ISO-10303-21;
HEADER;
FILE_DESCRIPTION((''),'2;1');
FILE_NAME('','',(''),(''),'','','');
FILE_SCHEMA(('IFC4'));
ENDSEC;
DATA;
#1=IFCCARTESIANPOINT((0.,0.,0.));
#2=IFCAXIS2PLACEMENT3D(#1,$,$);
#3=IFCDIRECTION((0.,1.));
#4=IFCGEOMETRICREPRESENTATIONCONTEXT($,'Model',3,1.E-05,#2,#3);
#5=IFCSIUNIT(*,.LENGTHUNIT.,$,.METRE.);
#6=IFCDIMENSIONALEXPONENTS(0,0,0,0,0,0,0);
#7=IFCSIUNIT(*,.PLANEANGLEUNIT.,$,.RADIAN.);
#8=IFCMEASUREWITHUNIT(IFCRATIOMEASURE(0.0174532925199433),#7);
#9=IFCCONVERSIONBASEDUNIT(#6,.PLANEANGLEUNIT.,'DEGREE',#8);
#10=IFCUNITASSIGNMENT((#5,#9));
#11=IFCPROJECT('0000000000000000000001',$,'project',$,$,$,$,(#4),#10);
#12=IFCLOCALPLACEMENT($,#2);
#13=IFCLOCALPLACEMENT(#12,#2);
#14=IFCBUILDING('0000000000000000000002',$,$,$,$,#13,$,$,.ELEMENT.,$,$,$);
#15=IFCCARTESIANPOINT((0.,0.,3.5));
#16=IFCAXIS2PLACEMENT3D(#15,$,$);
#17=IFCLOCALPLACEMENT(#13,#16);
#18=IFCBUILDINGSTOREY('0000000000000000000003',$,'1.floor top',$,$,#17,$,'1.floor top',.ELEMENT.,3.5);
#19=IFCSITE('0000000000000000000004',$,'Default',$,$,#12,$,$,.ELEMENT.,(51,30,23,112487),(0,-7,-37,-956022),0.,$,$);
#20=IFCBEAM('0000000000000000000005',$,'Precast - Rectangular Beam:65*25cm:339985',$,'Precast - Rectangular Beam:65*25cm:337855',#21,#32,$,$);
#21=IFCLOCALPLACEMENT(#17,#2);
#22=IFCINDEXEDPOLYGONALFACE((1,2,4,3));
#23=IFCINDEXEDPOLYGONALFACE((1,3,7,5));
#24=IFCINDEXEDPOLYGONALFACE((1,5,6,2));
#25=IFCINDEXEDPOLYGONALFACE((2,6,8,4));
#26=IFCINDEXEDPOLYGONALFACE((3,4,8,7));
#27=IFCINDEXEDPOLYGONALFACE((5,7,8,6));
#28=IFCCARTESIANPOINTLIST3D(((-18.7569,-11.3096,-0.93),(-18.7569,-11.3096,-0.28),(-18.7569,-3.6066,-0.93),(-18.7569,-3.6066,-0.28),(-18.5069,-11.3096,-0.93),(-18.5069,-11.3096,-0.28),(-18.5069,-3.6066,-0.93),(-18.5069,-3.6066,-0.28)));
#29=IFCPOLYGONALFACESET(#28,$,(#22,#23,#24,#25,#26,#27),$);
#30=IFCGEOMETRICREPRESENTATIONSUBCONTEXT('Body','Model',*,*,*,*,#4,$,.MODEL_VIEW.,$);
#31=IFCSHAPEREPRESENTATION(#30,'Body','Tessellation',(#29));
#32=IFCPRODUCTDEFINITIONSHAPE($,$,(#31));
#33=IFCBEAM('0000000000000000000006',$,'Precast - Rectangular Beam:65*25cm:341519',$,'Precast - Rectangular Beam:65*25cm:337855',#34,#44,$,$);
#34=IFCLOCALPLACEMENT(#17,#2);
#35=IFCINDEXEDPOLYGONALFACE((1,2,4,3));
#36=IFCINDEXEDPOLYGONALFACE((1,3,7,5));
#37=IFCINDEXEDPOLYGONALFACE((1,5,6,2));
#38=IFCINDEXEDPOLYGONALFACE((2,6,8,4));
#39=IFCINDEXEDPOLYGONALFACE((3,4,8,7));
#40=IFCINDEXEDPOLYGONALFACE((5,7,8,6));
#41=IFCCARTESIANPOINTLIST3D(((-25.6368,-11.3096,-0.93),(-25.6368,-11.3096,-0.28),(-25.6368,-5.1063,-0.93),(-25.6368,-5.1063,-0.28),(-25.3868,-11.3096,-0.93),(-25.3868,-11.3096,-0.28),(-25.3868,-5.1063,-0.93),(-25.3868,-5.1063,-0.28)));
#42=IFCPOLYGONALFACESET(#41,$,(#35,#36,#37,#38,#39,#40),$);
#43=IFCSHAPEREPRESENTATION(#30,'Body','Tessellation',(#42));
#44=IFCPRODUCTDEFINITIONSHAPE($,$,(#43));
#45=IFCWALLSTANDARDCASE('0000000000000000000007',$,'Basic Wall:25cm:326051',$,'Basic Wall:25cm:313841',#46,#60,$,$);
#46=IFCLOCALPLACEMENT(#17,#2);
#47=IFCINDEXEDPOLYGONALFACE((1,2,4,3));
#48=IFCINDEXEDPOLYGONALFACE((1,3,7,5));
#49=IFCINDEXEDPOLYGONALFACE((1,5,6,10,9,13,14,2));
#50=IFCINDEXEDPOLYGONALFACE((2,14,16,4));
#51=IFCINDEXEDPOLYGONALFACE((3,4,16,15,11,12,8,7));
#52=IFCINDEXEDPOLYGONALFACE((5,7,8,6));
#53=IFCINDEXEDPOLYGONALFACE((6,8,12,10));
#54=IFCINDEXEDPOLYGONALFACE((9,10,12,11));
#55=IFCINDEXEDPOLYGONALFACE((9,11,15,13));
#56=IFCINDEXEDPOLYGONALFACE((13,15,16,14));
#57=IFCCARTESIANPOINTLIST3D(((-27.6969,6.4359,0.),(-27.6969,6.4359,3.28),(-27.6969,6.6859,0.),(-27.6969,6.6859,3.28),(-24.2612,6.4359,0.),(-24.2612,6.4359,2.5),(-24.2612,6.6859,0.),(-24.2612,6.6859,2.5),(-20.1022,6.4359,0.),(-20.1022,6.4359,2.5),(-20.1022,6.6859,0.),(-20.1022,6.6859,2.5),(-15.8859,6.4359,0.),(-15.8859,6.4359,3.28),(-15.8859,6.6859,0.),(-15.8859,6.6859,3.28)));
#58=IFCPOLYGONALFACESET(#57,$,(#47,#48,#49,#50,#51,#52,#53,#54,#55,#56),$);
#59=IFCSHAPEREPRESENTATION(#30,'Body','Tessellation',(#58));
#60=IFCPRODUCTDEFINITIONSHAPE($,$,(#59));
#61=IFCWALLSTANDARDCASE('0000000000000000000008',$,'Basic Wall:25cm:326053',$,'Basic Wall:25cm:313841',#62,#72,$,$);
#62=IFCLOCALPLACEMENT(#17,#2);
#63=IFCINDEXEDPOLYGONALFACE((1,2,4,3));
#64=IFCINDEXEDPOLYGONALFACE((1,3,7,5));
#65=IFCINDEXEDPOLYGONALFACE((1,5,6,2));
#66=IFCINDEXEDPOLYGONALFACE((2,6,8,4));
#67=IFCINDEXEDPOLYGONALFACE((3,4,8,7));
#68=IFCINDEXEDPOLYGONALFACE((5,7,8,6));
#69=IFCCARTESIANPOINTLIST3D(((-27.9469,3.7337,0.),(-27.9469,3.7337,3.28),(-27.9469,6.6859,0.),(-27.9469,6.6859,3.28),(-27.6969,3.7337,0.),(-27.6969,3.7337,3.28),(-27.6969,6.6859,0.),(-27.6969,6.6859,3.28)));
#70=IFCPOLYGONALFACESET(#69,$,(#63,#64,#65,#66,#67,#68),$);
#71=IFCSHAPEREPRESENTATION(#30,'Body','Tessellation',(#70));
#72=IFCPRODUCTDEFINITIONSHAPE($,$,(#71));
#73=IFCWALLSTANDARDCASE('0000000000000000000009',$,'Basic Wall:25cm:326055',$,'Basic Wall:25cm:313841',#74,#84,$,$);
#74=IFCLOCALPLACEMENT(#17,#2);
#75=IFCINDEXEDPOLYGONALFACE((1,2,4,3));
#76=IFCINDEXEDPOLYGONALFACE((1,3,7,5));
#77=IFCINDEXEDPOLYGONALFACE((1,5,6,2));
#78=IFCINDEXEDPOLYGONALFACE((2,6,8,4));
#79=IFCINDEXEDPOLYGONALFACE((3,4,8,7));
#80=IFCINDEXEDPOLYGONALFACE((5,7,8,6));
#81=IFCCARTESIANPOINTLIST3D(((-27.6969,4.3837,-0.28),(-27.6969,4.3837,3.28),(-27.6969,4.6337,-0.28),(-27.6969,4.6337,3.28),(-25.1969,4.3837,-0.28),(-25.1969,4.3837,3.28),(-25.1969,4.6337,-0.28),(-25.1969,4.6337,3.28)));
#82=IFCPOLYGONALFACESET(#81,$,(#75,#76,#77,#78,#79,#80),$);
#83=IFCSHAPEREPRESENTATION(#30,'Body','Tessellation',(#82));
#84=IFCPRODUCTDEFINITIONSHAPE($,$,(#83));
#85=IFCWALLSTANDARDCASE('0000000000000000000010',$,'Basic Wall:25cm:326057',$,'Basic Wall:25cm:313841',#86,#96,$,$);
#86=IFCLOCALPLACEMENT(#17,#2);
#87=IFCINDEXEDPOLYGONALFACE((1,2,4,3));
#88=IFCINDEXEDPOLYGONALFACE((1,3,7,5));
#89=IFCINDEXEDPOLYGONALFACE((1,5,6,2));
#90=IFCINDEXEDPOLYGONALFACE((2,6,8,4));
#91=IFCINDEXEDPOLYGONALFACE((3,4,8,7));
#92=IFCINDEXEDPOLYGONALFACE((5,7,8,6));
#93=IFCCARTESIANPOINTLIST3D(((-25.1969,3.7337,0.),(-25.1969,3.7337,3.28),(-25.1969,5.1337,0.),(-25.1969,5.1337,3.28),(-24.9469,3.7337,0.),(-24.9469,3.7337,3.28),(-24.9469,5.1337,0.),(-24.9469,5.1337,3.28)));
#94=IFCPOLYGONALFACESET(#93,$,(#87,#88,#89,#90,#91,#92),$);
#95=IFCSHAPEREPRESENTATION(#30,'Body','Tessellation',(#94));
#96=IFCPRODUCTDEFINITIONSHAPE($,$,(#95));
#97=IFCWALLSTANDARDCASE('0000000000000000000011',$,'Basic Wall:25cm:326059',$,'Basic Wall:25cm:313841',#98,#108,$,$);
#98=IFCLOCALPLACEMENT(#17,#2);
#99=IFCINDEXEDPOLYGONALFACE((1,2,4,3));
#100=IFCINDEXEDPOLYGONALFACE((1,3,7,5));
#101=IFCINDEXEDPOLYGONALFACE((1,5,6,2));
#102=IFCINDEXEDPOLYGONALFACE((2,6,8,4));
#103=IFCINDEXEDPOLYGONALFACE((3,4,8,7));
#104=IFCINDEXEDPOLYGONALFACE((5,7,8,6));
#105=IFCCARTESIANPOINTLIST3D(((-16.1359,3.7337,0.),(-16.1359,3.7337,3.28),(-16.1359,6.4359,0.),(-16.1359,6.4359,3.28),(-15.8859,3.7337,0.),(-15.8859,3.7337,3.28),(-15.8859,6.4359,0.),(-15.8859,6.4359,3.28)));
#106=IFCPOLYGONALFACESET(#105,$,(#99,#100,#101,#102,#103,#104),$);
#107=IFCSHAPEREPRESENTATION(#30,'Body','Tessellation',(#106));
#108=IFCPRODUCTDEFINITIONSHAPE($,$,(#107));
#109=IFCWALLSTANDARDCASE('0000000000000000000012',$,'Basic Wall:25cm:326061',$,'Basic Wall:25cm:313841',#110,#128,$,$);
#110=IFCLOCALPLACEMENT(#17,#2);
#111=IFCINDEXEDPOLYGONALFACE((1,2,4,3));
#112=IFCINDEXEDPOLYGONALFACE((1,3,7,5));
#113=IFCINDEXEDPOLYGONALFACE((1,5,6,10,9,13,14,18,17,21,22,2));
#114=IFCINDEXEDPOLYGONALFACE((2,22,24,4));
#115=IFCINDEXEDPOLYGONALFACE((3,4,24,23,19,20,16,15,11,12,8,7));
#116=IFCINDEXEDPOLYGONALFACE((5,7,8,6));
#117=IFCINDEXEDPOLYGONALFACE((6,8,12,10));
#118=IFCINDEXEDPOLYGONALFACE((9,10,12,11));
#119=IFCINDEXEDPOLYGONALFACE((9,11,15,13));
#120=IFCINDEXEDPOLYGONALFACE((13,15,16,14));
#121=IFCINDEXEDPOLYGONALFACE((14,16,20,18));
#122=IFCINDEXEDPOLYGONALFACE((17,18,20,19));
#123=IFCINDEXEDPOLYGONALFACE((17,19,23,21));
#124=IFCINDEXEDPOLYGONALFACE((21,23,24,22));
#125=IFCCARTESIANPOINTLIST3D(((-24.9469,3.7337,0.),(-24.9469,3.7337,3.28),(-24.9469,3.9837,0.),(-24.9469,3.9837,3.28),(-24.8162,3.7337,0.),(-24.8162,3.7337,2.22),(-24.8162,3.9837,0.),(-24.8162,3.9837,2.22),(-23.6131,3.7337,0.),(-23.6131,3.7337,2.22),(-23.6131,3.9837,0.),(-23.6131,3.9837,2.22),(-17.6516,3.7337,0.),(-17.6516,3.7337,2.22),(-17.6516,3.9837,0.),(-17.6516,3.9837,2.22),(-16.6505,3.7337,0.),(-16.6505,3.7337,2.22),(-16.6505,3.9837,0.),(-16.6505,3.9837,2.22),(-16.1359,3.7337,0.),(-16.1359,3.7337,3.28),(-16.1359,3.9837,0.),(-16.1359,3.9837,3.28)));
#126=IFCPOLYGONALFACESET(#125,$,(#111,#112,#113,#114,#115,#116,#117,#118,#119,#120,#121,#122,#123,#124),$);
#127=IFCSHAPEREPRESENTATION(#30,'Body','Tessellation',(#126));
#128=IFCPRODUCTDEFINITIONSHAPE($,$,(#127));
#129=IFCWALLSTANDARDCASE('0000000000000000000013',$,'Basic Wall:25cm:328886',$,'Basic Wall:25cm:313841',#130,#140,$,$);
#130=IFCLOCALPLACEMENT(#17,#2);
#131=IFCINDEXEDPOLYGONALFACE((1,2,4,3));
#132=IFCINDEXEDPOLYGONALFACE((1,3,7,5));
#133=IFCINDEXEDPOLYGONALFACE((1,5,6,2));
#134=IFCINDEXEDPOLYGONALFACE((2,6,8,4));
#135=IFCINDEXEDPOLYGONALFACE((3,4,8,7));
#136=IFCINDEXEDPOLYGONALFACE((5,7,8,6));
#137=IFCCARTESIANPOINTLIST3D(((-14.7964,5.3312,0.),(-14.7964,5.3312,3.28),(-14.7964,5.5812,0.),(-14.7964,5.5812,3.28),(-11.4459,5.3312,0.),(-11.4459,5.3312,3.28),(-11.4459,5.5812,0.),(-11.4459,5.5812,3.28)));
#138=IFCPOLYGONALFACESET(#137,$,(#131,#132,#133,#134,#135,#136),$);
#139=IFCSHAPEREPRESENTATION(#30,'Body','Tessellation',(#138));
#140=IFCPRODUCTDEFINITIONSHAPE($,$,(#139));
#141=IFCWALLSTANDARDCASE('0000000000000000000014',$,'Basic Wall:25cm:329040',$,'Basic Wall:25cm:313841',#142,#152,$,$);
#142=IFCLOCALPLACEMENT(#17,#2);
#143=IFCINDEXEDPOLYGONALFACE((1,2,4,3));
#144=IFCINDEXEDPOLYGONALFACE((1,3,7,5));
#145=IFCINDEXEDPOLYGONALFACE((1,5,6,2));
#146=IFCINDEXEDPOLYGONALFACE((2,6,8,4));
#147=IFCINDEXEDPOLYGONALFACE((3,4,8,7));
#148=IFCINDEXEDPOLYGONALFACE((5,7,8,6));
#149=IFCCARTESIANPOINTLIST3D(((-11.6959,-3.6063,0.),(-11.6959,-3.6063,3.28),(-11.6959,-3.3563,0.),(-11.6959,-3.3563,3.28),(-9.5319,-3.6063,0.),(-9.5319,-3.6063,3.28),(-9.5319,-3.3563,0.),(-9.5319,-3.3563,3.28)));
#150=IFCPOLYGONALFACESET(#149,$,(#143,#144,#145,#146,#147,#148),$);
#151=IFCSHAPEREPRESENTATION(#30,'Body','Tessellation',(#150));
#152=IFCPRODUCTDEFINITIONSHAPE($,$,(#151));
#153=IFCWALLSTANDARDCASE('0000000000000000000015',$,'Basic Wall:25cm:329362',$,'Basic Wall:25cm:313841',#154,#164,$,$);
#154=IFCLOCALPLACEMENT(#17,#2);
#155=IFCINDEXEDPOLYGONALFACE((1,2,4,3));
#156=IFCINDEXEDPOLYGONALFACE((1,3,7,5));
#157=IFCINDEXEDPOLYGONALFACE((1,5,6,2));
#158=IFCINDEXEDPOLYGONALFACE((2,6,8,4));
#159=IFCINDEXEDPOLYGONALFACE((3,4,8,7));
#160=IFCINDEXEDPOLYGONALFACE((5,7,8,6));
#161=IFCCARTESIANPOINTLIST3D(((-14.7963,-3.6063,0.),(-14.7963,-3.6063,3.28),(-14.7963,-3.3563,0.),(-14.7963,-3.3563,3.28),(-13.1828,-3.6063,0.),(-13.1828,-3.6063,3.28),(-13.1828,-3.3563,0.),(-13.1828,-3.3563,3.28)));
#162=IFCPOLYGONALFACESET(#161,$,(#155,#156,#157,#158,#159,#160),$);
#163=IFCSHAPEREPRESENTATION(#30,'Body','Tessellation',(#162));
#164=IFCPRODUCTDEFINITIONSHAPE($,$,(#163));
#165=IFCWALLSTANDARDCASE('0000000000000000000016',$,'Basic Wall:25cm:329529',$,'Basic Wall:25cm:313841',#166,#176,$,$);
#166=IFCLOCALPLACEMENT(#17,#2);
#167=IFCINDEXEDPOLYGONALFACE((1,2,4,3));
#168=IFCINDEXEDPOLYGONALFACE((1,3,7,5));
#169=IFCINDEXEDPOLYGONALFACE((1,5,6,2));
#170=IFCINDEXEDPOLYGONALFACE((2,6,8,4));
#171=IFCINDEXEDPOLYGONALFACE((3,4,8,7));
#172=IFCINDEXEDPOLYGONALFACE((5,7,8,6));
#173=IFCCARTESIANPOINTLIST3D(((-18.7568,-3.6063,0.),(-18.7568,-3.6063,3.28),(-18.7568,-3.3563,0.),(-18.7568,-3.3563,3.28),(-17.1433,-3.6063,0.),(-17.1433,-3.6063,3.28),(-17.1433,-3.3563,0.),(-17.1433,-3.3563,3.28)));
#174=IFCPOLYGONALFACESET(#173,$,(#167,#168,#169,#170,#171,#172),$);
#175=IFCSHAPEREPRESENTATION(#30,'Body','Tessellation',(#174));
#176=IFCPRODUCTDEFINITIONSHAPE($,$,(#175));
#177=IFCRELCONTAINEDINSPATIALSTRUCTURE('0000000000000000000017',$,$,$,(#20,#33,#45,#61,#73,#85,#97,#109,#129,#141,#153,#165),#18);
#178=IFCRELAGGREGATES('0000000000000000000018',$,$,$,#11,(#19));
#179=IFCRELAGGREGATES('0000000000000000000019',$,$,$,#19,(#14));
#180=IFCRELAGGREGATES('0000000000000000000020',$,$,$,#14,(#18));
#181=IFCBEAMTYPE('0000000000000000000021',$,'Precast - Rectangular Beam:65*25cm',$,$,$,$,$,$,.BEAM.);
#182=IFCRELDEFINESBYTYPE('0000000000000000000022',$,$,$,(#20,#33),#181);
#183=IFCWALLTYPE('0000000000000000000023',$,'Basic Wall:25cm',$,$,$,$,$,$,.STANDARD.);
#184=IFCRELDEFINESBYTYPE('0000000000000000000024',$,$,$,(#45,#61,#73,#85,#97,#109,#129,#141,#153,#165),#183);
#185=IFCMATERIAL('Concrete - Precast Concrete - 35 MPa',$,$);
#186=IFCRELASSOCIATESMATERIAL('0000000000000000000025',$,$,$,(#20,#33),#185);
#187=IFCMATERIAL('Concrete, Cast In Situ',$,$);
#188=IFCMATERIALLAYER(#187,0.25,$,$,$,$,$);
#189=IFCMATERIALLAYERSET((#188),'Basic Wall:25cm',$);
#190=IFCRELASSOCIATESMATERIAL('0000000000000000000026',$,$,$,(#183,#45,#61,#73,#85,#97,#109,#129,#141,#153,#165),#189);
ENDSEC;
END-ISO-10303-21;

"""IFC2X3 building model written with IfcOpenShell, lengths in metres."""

from ifc_helpers import new_model, entity, si_unit, converted_unit, direction, frame, frame_2d, origin, origin_2d_with_axis, place, context, subcontext, project, spatial, rectangle, extrude, material, layer, layer_set, layer_usage, type_object, element, save


model = new_model("IFC2X3")

# Units and contexts
model_context = context("Model", 3, precision=1e-05, world=origin(), true_north=direction((0.0, 1.0)))
body_context = subcontext(model_context, "Body", "Model", "MODEL_VIEW")
ifc_project = project(units=[si_unit("LENGTHUNIT", "METRE"), converted_unit("PLANEANGLEUNIT", "DEGREE", entity("IfcRatioMeasure", 0.0174532925199433), si_unit("PLANEANGLEUNIT", "RADIAN"), dimensions=[0, 0, 0, 0, 0, 0, 0])], contexts=[model_context])

# Site, building, storey
site_placement = place(None, origin())
site = spatial("IfcSite", under=ifc_project, at=site_placement, Name="Default", CompositionType="ELEMENT", RefLatitude=(51, 30, 23, 112487), RefLongitude=(0, -7, -37, -956022), RefElevation=0.0)
building_placement = place(site_placement, origin())
building = spatial("IfcBuilding", under=site, at=building_placement, CompositionType="ELEMENT")
storey_placement = place(building_placement, frame((0.0, 0.0, 3.5)))
storey = spatial("IfcBuildingStorey", under=building, at=storey_placement, Name="1.floor top", LongName="1.floor top", CompositionType="ELEMENT", Elevation=3.5)

# Shared definitions
ifc_material_1 = material(Name="Concrete, Cast In Situ")

# Beams
ifc_material_2 = material(Name="Concrete - Precast Concrete - 35 MPa")
beam_type = type_object("IfcBeamType", Name="Precast - Rectangular Beam:65*25cm", PredefinedType="BEAM")
beam_1_placement = place(storey_placement, frame((-18.6319, -3.4813, -0.28), z_axis=(0.0, 0.0, 1.0), x_axis=(0.0, -1.0, 0.0)))
element("IfcBeam", 1, at=beam_1_placement, inside=storey, type_object=beam_type, material=ifc_material_2, Name="Precast - Rectangular Beam:65*25cm:339985", ObjectType="Precast - Rectangular Beam:65*25cm:337855", context=body_context, shape_type="SweptSolid", body=[
    extrude(rectangle(XDim=0.65, YDim=0.25, at=origin_2d_with_axis()), frame((0.1253, 0.0, -0.325), z_axis=(1.0, 0.0, 0.0), x_axis=(0.0, 0.0, -1.0)), (0.0, 0.0, 1.0), 7.703),
])
beam_2_placement = place(storey_placement, frame((-25.5118, -3.4813, -0.28), z_axis=(0.0, 0.0, 1.0), x_axis=(0.0, -1.0, 0.0)))
element("IfcBeam", 2, at=beam_2_placement, inside=storey, type_object=beam_type, material=ifc_material_2, Name="Precast - Rectangular Beam:65*25cm:341519", ObjectType="Precast - Rectangular Beam:65*25cm:337855", context=body_context, shape_type="SweptSolid", body=[
    extrude(rectangle(XDim=0.65, YDim=0.25, at=origin_2d_with_axis()), frame((1.625, 0.0, -0.325), z_axis=(1.0, 0.0, 0.0), x_axis=(0.0, 0.0, -1.0)), (0.0, 0.0, 1.0), 6.2033),
])

# Wall, opening
ifc_layer = layer(ifc_material_1, 0.25)
ifc_layer_set = layer_set([ifc_layer], Name="Basic Wall:25cm")
ifc_layer_usage_1 = layer_usage(ifc_layer_set, "AXIS2", "NEGATIVE", 0.125)
wall_type = type_object("IfcWallType", Name="Basic Wall:25cm", PredefinedType="STANDARD", material=ifc_layer_set)
wall_1_placement = place(storey_placement, frame((-15.8859, 6.5609, 0.0), z_axis=(0.0, 0.0, 1.0), x_axis=(-1.0, 0.0, 0.0)))
wall_1 = element("IfcWallStandardCase", 3, at=wall_1_placement, inside=storey, type_object=wall_type, material=ifc_layer_usage_1, Name="Basic Wall:25cm:326051", ObjectType="Basic Wall:25cm:313841", context=body_context, shape_type="SweptSolid", body=[
    extrude(rectangle(XDim=11.811, YDim=0.25, at=frame_2d((5.9055, 0.0), x_axis=(-1.0, 0.0))), origin(), (0.0, 0.0, 1.0), 3.28),
])
opening_1_placement = place(wall_1_placement, origin())
element("IfcOpeningElement", 4, at=opening_1_placement, cuts=wall_1, ObjectType="Opening", context=body_context, shape_type="SweptSolid", body=[
    extrude(rectangle(XDim=2.5, YDim=4.1591, at=frame_2d((0.0, 0.0), x_axis=(1.0, 0.0))), frame((6.2958, -0.125, 1.25), z_axis=(0.0, 1.0, 0.0), x_axis=(0.0, 0.0, -1.0)), (0.0, 0.0, 1.0), 0.25),
])

# Walls
ifc_layer_usage_2 = layer_usage(ifc_layer_set, "AXIS2", "NEGATIVE", 0.125)
wall_2_placement = place(storey_placement, frame((-27.8219, 6.6859, 0.0), z_axis=(0.0, 0.0, 1.0), x_axis=(0.0, -1.0, 0.0)))
element("IfcWallStandardCase", 5, at=wall_2_placement, inside=storey, type_object=wall_type, material=ifc_layer_usage_2, Name="Basic Wall:25cm:326053", ObjectType="Basic Wall:25cm:313841", context=body_context, shape_type="SweptSolid", body=[
    extrude(rectangle(XDim=2.9523, YDim=0.25, at=frame_2d((1.4761, 0.0), x_axis=(-1.0, 0.0))), origin(), (0.0, 0.0, 1.0), 3.28),
])
ifc_layer_usage_3 = layer_usage(ifc_layer_set, "AXIS2", "POSITIVE", -0.125)
wall_3_placement = place(storey_placement, frame((-27.6969, 4.5087, -0.28)))
element("IfcWallStandardCase", 6, at=wall_3_placement, inside=storey, type_object=wall_type, material=ifc_layer_usage_3, Name="Basic Wall:25cm:326055", ObjectType="Basic Wall:25cm:313841", context=body_context, shape_type="SweptSolid", body=[
    extrude(rectangle(XDim=2.5, YDim=0.25, at=frame_2d((1.25, 0.0), x_axis=(-1.0, 0.0))), origin(), (0.0, 0.0, 1.0), 3.56),
])
ifc_layer_usage_4 = layer_usage(ifc_layer_set, "AXIS2", "NEGATIVE", 0.125)
wall_4_placement = place(storey_placement, frame((-25.0719, 5.1337, 0.0), z_axis=(0.0, 0.0, 1.0), x_axis=(0.0, -1.0, 0.0)))
element("IfcWallStandardCase", 7, at=wall_4_placement, inside=storey, type_object=wall_type, material=ifc_layer_usage_4, Name="Basic Wall:25cm:326057", ObjectType="Basic Wall:25cm:313841", context=body_context, shape_type="SweptSolid", body=[
    extrude(rectangle(XDim=1.4, YDim=0.25, at=frame_2d((0.7, 0.0), x_axis=(-1.0, 0.0))), origin(), (0.0, 0.0, 1.0), 3.28),
])
ifc_layer_usage_5 = layer_usage(ifc_layer_set, "AXIS2", "POSITIVE", -0.125)
wall_5_placement = place(storey_placement, frame((-16.0109, 6.4359, 0.0), z_axis=(0.0, 0.0, 1.0), x_axis=(0.0, -1.0, 0.0)))
element("IfcWallStandardCase", 8, at=wall_5_placement, inside=storey, type_object=wall_type, material=ifc_layer_usage_5, Name="Basic Wall:25cm:326059", ObjectType="Basic Wall:25cm:313841", context=body_context, shape_type="SweptSolid", body=[
    extrude(rectangle(XDim=2.7022, YDim=0.25, at=frame_2d((1.3511, 0.0), x_axis=(-1.0, 0.0))), origin(), (0.0, 0.0, 1.0), 3.28),
])

# Wall, openings
ifc_layer_usage_6 = layer_usage(ifc_layer_set, "AXIS2", "POSITIVE", -0.125)
wall_6_placement = place(storey_placement, frame((-16.1359, 3.8587, 0.0), z_axis=(0.0, 0.0, 1.0), x_axis=(-1.0, -0.000001, 0.0)))
wall_6 = element("IfcWallStandardCase", 9, at=wall_6_placement, inside=storey, type_object=wall_type, material=ifc_layer_usage_6, Name="Basic Wall:25cm:326061", ObjectType="Basic Wall:25cm:313841", context=body_context, shape_type="SweptSolid", body=[
    extrude(rectangle(XDim=8.811, YDim=0.25, at=frame_2d((4.4055, 0.0), x_axis=(-1.0, 0.0))), origin(), (0.0, 0.0, 1.0), 3.28),
])
opening_2_placement = place(wall_6_placement, origin())
element("IfcOpeningElement", 10, at=opening_2_placement, cuts=wall_6, ObjectType="Opening", context=body_context, shape_type="SweptSolid", body=[
    extrude(rectangle(XDim=2.22, YDim=1.2031, at=frame_2d((0.0, 0.0), x_axis=(1.0, 0.0))), frame((8.0788, -0.125, 1.11), z_axis=(0.0, 1.0, 0.0), x_axis=(0.0, 0.0, -1.0)), (0.0, 0.0, 1.0), 0.25),
])
opening_3_placement = place(wall_6_placement, origin())
element("IfcOpeningElement", 11, at=opening_3_placement, cuts=wall_6, ObjectType="Opening", context=body_context, shape_type="SweptSolid", body=[
    extrude(rectangle(XDim=2.22, YDim=1.0011, at=frame_2d((0.0, 0.0), x_axis=(1.0, 0.0))), frame((1.0152, -0.125, 1.11), z_axis=(0.0, 1.0, 0.0), x_axis=(0.0, 0.0, -1.0)), (0.0, 0.0, 1.0), 0.25),
])

# Walls
ifc_layer_usage_7 = layer_usage(ifc_layer_set, "AXIS2", "POSITIVE", -0.125)
wall_7_placement = place(storey_placement, frame((-14.7964, 5.4562, 0.0)))
element("IfcWallStandardCase", 12, at=wall_7_placement, inside=storey, type_object=wall_type, material=ifc_layer_usage_7, Name="Basic Wall:25cm:328886", ObjectType="Basic Wall:25cm:313841", context=body_context, shape_type="SweptSolid", body=[
    extrude(rectangle(XDim=3.3505, YDim=0.25, at=frame_2d((1.6752, 0.0), x_axis=(-1.0, 0.0))), origin(), (0.0, 0.0, 1.0), 3.28),
])
ifc_layer_usage_8 = layer_usage(ifc_layer_set, "AXIS2", "NEGATIVE", 0.125)
wall_8_placement = place(storey_placement, frame((-11.6959, -3.4813, 0.0)))
element("IfcWallStandardCase", 13, at=wall_8_placement, inside=storey, type_object=wall_type, material=ifc_layer_usage_8, Name="Basic Wall:25cm:329040", ObjectType="Basic Wall:25cm:313841", context=body_context, shape_type="SweptSolid", body=[
    extrude(rectangle(XDim=2.164, YDim=0.25, at=frame_2d((1.082, 0.0), x_axis=(-1.0, 0.0))), origin(), (0.0, 0.0, 1.0), 3.28),
])
ifc_layer_usage_9 = layer_usage(ifc_layer_set, "AXIS2", "POSITIVE", -0.125)
wall_9_placement = place(storey_placement, frame((-13.1828, -3.4813, 0.0), z_axis=(0.0, 0.0, 1.0), x_axis=(-1.0, 0.0, 0.0)))
element("IfcWallStandardCase", 14, at=wall_9_placement, inside=storey, type_object=wall_type, material=ifc_layer_usage_9, Name="Basic Wall:25cm:329362", ObjectType="Basic Wall:25cm:313841", context=body_context, shape_type="SweptSolid", body=[
    extrude(rectangle(XDim=1.6135, YDim=0.25, at=frame_2d((0.8068, 0.0), x_axis=(-1.0, 0.0))), origin(), (0.0, 0.0, 1.0), 3.28),
])
ifc_layer_usage_10 = layer_usage(ifc_layer_set, "AXIS2", "NEGATIVE", 0.125)
wall_10_placement = place(storey_placement, frame((-18.7568, -3.4813, 0.0)))
element("IfcWallStandardCase", 15, at=wall_10_placement, inside=storey, type_object=wall_type, material=ifc_layer_usage_10, Name="Basic Wall:25cm:329529", ObjectType="Basic Wall:25cm:313841", context=body_context, shape_type="SweptSolid", body=[
    extrude(rectangle(XDim=1.6135, YDim=0.25, at=frame_2d((0.8068, 0.0), x_axis=(-1.0, 0.0))), origin(), (0.0, 0.0, 1.0), 3.28),
])

save(model, "model.ifc")
